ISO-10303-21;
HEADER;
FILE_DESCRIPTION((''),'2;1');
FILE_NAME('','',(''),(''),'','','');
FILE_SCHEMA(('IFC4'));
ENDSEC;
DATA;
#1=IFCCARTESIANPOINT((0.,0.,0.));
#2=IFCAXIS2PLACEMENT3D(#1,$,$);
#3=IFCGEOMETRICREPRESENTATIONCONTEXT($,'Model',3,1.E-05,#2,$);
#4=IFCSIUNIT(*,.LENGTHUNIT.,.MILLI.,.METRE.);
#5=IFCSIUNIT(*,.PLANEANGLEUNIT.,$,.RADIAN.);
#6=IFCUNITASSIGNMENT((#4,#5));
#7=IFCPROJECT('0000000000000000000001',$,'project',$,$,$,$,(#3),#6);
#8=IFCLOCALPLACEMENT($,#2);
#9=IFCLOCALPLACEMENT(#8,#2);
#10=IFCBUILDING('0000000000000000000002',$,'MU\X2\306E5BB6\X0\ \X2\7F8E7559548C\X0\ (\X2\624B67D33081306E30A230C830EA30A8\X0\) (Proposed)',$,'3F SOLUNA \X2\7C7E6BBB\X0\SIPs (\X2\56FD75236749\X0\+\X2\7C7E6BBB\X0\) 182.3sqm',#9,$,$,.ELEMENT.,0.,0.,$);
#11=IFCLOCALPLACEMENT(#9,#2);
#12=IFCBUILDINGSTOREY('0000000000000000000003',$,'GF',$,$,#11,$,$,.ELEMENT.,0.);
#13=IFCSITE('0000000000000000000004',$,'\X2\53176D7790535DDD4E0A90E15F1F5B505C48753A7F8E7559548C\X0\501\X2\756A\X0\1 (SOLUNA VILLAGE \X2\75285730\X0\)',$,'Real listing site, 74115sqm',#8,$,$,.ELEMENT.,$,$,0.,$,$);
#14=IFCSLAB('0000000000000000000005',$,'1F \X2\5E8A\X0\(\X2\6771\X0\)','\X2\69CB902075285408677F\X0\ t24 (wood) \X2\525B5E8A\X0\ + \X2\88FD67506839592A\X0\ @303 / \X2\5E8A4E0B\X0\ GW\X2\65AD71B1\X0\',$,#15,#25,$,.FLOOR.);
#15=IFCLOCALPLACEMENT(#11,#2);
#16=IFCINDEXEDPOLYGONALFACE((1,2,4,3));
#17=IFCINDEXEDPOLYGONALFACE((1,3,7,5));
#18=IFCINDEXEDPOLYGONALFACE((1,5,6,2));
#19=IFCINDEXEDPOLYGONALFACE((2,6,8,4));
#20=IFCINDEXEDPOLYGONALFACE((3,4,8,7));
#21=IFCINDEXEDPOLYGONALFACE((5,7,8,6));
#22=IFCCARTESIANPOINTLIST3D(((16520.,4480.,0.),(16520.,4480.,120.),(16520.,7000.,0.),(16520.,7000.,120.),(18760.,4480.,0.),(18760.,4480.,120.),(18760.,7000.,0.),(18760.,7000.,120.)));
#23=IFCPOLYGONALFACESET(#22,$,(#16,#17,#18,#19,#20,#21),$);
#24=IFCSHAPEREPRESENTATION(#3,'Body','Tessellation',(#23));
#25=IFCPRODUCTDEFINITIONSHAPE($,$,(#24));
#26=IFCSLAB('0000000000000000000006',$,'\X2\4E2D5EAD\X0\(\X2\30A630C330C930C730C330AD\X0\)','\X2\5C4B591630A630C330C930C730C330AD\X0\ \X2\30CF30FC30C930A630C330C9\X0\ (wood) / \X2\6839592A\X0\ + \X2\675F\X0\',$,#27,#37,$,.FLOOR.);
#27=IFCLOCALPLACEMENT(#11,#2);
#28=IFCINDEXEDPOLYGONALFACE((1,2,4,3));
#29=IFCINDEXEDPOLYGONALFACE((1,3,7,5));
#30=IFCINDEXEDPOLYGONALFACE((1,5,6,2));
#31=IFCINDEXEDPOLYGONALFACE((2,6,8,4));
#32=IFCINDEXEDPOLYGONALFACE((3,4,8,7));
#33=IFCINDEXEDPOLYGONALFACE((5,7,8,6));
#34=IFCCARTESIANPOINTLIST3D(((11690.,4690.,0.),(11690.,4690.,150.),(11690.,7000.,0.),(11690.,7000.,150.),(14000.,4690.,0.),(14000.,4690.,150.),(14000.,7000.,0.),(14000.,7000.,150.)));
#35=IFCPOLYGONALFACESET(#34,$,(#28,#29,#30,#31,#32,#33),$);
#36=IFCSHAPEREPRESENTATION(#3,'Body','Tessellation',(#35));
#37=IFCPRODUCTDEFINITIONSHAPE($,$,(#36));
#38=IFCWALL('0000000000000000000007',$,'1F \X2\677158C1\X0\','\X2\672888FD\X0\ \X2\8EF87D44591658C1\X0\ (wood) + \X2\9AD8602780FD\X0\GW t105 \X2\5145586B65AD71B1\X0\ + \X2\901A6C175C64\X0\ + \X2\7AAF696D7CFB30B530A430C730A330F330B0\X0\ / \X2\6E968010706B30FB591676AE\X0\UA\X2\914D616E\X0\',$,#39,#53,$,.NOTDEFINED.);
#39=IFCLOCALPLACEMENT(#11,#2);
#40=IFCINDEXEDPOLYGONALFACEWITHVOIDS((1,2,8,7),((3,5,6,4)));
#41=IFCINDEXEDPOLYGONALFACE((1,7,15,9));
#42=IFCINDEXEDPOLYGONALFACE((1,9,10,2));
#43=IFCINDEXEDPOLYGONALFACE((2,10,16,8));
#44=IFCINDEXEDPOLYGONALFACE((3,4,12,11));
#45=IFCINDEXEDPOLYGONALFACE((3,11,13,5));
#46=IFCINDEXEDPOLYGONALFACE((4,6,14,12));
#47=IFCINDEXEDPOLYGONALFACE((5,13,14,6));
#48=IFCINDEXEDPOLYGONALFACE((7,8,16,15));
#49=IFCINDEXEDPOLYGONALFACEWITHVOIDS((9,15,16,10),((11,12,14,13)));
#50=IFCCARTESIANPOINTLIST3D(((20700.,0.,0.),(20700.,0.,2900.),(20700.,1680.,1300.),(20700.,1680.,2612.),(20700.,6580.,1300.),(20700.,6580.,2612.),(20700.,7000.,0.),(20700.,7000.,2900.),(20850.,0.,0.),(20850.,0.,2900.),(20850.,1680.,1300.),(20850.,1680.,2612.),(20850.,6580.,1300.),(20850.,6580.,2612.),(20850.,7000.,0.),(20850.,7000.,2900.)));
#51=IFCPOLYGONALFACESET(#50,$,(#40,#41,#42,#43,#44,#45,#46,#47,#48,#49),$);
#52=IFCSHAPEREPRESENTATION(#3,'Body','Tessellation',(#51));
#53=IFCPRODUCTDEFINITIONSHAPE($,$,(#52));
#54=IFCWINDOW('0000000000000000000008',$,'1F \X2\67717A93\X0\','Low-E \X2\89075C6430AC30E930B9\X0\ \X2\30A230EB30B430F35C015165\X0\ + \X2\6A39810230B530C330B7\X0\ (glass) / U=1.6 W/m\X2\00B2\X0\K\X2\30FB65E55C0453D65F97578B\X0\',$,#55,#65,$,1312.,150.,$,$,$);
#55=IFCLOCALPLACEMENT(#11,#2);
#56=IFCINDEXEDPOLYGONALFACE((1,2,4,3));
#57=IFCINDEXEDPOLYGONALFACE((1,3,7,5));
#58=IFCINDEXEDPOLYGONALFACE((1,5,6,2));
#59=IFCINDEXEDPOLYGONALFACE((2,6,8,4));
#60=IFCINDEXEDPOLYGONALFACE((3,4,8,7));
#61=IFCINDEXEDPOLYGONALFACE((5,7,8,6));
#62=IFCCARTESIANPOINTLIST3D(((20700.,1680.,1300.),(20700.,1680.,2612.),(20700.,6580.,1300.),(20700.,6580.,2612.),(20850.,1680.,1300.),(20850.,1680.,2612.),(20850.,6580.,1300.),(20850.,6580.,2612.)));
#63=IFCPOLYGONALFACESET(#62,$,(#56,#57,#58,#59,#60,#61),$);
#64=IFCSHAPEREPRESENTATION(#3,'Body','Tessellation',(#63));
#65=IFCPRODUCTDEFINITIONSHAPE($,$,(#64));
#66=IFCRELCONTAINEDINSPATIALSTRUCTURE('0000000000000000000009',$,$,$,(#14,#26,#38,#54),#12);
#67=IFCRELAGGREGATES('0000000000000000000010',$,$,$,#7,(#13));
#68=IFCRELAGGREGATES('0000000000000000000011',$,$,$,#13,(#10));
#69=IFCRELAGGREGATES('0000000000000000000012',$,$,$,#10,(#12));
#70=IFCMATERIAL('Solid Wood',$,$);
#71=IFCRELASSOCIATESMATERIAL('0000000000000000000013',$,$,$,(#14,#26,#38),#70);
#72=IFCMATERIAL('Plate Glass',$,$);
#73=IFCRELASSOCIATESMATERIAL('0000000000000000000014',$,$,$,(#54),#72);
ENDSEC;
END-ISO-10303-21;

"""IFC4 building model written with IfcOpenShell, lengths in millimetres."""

from ifc_helpers import new_model, si_unit, frame, frame_2d, origin, place, context, project, spatial, rectangle, extrude, material, element, fill, save


model = new_model("IFC4")

# Units and contexts
model_context = context("Model", 3, precision=1e-05, world=origin())
ifc_project = project(units=[si_unit("LENGTHUNIT", "METRE", prefix="MILLI"), si_unit("PLANEANGLEUNIT", "RADIAN")], contexts=[model_context])

# Site, building, storey
site_placement = place(None, origin())
site = spatial("IfcSite", under=ifc_project, at=site_placement, Name="北海道川上郡弟子屈町美留和501番1 (SOLUNA VILLAGE 用地)", ObjectType="Real listing site, 74115sqm", CompositionType="ELEMENT", RefElevation=0.0)
building_placement = place(site_placement, origin())
building = spatial("IfcBuilding", under=site, at=building_placement, Name="MUの家 美留和 (手染めのアトリエ) (Proposed)", ObjectType="3F SOLUNA 籾殻SIPs (国産杉+籾殻) 182.3sqm", CompositionType="ELEMENT", ElevationOfRefHeight=0.0, ElevationOfTerrain=0.0)
storey_placement = place(building_placement, origin())
storey = spatial("IfcBuildingStorey", under=building, at=storey_placement, Name="GF", CompositionType="ELEMENT", Elevation=0.0)

# Slabs
ifc_material_1 = material(Name="Solid Wood")
slab_1_placement = place(storey_placement, frame((8260.0, 2240.0, 0.0)))
element("IfcSlab", 1, at=slab_1_placement, inside=storey, material=ifc_material_1, Name="1F 床(東)", Description="構造用合板 t24 (wood) 剛床 + 製材根太 @303 / 床下 GW断熱", PredefinedType="FLOOR", context=model_context, shape_type="SweptSolid", body=[
    extrude(rectangle(XDim=2240.0, YDim=2520.0, at=frame_2d((1120.0, 1260.0))), frame((8260.0, 2240.0, 0.0)), (0.0, 0.0, 1.0), 120.0),
])
slab_2_placement = place(storey_placement, frame((5845.0, 2345.0, 0.0)))
element("IfcSlab", 2, at=slab_2_placement, inside=storey, material=ifc_material_1, Name="中庭(ウッドデッキ)", Description="屋外ウッドデッキ ハードウッド (wood) / 根太 + 束", PredefinedType="FLOOR", context=model_context, shape_type="SweptSolid", body=[
    extrude(rectangle(XDim=2310.0, YDim=2310.0, at=frame_2d((1155.0, 1155.0))), frame((5845.0, 2345.0, 0.0)), (0.0, 0.0, 1.0), 150.0),
])

# Wall, opening, window
wall_1_placement = place(storey_placement, frame((10350.0, 0.0, 0.0)))
wall_1 = element("IfcWall", 3, at=wall_1_placement, inside=storey, material=ifc_material_1, Name="1F 東壁", Description="木製 軸組外壁 (wood) + 高性能GW t105 充填断熱 + 通気層 + 窯業系サイディング / 準耐火・外皮UA配慮", PredefinedType="NOTDEFINED", context=model_context, shape_type="SweptSolid", body=[
    extrude(rectangle(XDim=150.0, YDim=7000.0, at=frame_2d((75.0, 3500.0))), frame((10350.0, 0.0, 0.0)), (0.0, 0.0, 1.0), 2900.0),
])
opening_1_placement = place(storey_placement, frame((10350.0, 840.0, 650.0)))
opening_1 = element("IfcOpeningElement", 4, at=opening_1_placement, cuts=wall_1, PredefinedType="NOTDEFINED", context=model_context, shape_type="SweptSolid", body=[
    extrude(rectangle(XDim=150.0, YDim=4900.0, at=frame_2d((75.0, 2450.0))), frame((10350.0, 840.0, 650.0)), (0.0, 0.0, 1.0), 1312.0),
])
ifc_material_2 = material(Name="Plate Glass")
window_1_placement = place(storey_placement, frame((10350.0, 840.0, 650.0)))
window_1 = element("IfcWindow", 5, at=window_1_placement, inside=storey, material=ifc_material_2, Name="1F 東窓", Description="Low-E 複層ガラス アルゴン封入 + 樹脂サッシ (glass) / U=1.6 W/m²K・日射取得型", OverallHeight=1312.0, OverallWidth=150.0, context=model_context, shape_type="SweptSolid", body=[
    extrude(rectangle(XDim=150.0, YDim=4900.0, at=frame_2d((75.0, 2450.0))), frame((10350.0, 840.0, 650.0)), (0.0, 0.0, 1.0), 1312.0),
])
fill(opening_1, window_1)

save(model, "model.ifc")
